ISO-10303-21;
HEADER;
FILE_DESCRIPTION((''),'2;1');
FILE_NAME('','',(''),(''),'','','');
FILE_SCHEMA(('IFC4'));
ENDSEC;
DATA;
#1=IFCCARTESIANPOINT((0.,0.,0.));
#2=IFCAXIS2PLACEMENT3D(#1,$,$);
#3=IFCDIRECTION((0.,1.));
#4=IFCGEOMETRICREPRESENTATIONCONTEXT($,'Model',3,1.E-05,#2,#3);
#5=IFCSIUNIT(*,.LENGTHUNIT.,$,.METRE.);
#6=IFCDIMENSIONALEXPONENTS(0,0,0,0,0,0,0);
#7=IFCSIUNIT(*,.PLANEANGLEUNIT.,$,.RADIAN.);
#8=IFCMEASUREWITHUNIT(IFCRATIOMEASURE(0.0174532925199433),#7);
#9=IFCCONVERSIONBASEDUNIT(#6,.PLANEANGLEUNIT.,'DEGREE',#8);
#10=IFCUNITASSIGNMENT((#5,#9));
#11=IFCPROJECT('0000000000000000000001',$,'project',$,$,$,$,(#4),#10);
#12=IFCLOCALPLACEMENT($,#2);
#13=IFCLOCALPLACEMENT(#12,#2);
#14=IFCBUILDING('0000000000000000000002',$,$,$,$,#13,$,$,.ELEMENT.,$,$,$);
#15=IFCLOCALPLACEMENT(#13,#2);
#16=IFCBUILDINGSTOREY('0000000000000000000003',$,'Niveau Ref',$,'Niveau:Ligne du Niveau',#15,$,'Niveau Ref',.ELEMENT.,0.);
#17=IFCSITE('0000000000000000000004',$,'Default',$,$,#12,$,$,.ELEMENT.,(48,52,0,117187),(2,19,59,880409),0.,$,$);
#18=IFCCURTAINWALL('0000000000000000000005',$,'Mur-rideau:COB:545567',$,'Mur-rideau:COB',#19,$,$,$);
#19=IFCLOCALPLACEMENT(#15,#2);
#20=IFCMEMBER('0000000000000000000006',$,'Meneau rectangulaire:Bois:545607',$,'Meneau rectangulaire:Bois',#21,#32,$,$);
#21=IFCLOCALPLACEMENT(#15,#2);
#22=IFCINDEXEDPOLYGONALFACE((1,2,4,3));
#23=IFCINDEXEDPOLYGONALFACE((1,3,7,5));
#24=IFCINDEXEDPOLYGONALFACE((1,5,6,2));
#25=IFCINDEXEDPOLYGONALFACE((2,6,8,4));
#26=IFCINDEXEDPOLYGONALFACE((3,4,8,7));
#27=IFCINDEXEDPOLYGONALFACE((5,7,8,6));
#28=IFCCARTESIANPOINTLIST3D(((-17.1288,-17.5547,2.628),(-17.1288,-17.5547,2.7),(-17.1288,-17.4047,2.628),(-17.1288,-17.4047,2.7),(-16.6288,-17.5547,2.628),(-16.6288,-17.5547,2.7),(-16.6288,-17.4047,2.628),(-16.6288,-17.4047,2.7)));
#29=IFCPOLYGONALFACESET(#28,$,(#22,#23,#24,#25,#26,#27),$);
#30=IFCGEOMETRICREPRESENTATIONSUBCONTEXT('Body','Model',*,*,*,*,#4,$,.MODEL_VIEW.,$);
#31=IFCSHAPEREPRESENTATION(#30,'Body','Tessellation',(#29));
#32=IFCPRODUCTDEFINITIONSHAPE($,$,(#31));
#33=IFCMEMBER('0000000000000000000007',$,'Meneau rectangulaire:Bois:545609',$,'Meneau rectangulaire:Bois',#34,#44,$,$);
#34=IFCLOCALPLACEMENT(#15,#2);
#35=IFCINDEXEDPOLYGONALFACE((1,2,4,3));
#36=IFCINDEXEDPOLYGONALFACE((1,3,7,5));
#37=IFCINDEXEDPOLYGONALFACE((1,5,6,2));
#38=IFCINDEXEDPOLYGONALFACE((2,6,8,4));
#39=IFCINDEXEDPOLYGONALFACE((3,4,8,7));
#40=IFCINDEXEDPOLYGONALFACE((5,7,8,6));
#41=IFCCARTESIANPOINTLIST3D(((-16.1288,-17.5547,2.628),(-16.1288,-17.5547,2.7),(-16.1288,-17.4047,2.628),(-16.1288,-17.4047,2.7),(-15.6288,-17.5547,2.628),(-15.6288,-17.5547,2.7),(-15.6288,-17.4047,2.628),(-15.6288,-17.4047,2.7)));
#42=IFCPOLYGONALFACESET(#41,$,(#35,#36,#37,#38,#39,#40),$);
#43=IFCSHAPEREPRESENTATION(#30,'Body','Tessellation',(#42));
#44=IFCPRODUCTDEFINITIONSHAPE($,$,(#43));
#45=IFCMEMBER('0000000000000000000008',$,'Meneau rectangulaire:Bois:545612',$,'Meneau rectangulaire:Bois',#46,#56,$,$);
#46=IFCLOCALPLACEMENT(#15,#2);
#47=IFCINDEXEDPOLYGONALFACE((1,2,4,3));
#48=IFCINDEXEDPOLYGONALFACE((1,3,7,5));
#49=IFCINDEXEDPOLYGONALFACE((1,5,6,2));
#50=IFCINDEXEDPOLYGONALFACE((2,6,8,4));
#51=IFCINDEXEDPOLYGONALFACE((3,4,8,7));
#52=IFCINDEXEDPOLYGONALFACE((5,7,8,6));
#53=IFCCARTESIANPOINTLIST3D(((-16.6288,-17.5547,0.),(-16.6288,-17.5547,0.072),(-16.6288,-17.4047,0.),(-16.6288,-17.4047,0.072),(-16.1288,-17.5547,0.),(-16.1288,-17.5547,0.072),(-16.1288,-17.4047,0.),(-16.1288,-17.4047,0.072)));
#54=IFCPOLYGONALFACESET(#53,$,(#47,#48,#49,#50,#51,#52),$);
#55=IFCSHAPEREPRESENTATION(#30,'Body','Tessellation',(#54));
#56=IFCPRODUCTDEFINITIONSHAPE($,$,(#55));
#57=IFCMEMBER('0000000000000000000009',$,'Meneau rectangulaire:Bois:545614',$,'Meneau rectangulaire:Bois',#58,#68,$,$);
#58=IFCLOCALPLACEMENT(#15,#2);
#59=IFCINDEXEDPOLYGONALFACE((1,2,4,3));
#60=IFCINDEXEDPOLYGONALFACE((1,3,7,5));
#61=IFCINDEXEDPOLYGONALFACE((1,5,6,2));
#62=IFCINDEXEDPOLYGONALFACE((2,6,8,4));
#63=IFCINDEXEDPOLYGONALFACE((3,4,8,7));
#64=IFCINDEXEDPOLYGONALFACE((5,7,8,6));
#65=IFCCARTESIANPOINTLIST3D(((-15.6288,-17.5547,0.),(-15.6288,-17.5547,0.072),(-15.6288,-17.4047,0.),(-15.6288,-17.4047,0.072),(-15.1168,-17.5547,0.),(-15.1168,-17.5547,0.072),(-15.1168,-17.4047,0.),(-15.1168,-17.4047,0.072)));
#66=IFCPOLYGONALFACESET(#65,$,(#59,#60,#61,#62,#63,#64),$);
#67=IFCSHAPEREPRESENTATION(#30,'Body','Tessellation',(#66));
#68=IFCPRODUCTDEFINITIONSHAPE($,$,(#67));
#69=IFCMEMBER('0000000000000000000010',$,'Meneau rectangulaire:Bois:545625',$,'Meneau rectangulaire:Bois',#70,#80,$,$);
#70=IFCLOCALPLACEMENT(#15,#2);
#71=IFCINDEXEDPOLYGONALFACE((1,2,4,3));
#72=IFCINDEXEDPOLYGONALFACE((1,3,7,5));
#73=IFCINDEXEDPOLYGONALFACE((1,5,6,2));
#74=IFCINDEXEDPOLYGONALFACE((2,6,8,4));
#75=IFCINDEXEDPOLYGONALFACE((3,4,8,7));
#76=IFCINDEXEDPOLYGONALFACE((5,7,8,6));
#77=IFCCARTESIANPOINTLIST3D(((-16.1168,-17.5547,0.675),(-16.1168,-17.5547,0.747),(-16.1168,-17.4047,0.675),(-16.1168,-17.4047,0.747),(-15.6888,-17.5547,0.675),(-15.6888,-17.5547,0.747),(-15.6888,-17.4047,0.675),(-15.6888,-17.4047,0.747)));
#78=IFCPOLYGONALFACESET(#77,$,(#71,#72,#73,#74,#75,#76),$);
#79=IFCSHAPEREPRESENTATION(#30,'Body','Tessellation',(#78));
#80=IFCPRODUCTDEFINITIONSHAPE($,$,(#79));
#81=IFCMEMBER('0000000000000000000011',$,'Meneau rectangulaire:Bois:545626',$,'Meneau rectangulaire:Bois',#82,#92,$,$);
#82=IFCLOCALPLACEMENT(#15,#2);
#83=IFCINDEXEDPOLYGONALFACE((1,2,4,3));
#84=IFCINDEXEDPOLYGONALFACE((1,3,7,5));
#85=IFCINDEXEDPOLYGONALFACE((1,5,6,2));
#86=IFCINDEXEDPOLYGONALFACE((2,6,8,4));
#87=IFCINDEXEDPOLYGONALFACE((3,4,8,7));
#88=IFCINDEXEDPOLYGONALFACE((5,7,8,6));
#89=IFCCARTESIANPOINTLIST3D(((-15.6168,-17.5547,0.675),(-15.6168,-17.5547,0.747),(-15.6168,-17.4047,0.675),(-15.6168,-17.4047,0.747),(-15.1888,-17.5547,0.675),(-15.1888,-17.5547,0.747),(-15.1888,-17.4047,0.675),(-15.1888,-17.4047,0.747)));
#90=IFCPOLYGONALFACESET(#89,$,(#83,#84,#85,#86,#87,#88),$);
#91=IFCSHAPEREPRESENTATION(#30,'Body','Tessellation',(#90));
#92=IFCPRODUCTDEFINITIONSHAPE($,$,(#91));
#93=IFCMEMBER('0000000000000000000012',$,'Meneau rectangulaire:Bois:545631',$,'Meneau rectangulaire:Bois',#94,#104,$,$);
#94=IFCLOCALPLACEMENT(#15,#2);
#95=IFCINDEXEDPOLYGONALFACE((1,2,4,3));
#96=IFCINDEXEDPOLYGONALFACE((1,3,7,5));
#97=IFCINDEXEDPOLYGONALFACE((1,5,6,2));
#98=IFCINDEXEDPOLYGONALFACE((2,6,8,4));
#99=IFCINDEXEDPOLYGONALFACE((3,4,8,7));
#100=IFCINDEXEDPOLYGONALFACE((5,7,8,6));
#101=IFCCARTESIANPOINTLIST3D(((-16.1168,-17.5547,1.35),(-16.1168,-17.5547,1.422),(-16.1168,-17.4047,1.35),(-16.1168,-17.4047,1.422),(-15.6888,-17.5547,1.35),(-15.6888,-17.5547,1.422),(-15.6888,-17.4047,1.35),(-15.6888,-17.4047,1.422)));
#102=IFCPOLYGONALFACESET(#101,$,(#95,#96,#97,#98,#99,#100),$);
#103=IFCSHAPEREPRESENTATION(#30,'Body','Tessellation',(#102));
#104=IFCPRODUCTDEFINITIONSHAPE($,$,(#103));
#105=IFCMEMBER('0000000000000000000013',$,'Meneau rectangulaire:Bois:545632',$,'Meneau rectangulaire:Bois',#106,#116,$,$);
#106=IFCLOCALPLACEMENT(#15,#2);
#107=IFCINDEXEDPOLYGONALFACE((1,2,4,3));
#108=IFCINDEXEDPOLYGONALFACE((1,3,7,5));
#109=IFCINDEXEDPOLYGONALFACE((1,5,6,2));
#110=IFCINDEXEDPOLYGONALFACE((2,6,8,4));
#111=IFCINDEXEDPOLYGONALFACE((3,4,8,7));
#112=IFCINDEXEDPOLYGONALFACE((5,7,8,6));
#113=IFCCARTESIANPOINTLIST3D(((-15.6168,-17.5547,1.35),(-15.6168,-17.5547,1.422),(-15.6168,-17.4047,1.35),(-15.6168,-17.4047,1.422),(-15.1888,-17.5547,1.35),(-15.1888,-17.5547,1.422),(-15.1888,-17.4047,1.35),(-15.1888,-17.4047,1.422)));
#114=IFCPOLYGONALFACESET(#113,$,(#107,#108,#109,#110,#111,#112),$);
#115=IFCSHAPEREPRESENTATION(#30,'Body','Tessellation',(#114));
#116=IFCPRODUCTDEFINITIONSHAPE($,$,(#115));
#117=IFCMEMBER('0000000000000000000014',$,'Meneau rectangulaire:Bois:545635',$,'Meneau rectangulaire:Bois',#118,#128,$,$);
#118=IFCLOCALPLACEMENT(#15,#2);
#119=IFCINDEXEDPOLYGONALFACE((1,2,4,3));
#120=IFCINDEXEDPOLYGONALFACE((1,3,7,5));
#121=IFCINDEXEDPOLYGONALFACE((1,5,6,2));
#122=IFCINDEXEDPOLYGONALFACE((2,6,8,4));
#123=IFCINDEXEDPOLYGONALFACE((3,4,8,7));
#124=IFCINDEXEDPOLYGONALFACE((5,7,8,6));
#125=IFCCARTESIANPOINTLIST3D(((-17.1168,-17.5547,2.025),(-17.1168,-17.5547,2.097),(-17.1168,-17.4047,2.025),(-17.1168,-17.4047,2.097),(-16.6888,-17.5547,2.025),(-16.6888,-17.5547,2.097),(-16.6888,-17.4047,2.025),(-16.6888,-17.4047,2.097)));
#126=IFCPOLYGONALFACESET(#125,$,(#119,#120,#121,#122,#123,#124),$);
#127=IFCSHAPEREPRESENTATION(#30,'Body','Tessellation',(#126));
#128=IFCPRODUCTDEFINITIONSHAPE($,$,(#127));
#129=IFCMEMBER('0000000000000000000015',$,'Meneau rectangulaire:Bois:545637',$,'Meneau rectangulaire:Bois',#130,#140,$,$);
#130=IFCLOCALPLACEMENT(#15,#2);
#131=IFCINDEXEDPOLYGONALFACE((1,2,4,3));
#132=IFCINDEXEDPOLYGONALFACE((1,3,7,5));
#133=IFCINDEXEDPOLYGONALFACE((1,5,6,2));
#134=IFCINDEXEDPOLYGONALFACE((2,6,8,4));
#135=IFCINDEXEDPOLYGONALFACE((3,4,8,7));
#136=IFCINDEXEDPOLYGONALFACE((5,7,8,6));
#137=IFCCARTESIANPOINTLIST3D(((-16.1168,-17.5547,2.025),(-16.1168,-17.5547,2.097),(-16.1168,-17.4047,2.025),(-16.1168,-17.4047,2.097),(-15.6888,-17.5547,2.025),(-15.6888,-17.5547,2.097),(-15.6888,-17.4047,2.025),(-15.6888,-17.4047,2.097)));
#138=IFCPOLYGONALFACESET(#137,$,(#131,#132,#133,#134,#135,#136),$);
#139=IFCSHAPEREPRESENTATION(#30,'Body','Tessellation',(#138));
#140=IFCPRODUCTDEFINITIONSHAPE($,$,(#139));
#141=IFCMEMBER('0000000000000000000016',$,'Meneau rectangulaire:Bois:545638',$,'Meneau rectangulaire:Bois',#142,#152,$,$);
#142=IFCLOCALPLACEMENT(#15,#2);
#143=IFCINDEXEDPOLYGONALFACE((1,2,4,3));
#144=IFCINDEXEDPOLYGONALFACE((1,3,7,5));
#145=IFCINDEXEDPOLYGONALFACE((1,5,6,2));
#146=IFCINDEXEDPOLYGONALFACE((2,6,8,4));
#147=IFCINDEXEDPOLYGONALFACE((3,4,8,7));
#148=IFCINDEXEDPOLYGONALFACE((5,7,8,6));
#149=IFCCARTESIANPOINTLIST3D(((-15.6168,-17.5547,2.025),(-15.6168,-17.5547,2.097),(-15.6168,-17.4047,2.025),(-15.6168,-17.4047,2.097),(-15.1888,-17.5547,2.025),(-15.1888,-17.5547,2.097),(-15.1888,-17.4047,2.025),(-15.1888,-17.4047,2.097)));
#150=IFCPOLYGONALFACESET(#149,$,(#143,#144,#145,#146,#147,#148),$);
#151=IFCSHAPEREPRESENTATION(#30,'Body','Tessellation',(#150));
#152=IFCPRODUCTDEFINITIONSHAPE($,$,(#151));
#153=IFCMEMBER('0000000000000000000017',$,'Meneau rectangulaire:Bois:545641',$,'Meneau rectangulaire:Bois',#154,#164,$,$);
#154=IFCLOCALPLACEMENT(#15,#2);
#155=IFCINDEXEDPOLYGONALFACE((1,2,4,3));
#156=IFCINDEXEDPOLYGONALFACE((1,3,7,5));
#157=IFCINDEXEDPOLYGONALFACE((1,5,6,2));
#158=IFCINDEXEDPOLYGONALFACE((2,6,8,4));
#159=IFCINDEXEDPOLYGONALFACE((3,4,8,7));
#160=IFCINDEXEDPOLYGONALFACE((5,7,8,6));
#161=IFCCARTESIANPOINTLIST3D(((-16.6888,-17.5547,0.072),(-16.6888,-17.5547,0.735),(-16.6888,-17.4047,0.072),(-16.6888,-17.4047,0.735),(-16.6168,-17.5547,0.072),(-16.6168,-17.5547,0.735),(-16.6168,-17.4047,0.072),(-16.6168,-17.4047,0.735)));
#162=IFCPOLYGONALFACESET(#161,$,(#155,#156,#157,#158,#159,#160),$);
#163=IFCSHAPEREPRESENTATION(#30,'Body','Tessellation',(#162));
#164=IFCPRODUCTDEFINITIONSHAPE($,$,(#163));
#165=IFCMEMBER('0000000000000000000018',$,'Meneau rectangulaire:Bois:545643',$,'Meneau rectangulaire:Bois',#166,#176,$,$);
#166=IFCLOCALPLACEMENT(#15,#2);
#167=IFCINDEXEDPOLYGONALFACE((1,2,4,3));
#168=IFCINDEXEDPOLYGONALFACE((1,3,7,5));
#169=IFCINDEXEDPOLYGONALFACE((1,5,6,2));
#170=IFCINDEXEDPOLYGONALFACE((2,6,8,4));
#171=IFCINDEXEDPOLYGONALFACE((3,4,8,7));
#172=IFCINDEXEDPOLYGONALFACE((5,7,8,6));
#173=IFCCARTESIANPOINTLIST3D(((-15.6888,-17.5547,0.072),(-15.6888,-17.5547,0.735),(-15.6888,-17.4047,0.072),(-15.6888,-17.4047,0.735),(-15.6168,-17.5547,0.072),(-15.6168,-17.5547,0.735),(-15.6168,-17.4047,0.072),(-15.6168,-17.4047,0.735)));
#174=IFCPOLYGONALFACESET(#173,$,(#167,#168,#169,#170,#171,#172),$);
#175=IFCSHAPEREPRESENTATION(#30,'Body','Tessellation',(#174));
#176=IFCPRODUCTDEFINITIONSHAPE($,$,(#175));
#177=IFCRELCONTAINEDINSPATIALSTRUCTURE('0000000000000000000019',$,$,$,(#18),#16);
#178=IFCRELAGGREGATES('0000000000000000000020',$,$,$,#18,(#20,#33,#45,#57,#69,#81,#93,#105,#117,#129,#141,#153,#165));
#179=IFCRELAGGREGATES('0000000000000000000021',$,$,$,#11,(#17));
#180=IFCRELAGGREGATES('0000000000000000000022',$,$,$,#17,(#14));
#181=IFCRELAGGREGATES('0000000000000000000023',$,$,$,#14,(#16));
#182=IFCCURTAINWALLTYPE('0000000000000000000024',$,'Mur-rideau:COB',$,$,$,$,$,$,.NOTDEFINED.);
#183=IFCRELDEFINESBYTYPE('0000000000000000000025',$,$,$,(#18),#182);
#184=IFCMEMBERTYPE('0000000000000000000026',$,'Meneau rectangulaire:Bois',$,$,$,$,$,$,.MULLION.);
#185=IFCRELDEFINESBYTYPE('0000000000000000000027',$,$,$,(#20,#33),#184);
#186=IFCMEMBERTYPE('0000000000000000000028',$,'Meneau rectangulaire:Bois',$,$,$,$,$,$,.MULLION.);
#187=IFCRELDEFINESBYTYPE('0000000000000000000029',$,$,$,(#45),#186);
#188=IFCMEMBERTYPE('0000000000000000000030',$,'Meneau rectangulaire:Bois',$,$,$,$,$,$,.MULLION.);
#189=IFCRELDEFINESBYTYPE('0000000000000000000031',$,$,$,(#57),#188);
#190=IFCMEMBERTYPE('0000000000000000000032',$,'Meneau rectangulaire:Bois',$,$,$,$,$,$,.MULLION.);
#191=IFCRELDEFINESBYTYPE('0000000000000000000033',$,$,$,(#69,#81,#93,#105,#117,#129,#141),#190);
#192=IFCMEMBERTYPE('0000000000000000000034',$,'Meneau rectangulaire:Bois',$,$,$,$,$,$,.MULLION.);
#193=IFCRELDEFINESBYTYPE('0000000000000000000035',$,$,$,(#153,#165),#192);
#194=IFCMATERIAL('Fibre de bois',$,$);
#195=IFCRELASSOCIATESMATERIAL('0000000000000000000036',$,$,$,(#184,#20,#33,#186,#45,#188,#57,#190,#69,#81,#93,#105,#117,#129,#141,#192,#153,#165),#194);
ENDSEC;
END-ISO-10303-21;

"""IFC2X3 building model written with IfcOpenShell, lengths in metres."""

from ifc_helpers import new_model, entity, si_unit, converted_unit, direction, frame, origin, origin_2d_with_axis, place, context, subcontext, project, spatial, rectangle, extrude, source, transform, mapped, material, type_object, type_shapes, element, aggregate, save


model = new_model("IFC2X3")

# Units and contexts
model_context = context("Model", 3, precision=1e-05, world=origin(), true_north=direction((0.0, 1.0)))
body_context = subcontext(model_context, "Body", "Model", "MODEL_VIEW")
ifc_project = project(units=[si_unit("LENGTHUNIT", "METRE"), converted_unit("PLANEANGLEUNIT", "DEGREE", entity("IfcRatioMeasure", 0.0174532925199433), si_unit("PLANEANGLEUNIT", "RADIAN"), dimensions=[0, 0, 0, 0, 0, 0, 0])], contexts=[model_context])

# Site, building, storey
site_placement = place(None, origin())
site = spatial("IfcSite", under=ifc_project, at=site_placement, Name="Default", CompositionType="ELEMENT", RefLatitude=(48, 52, 0, 117187), RefLongitude=(2, 19, 59, 880409), RefElevation=0.0)
building_placement = place(site_placement, origin())
building = spatial("IfcBuilding", under=site, at=building_placement, CompositionType="ELEMENT")
storey_placement = place(building_placement, origin())
storey = spatial("IfcBuildingStorey", under=building, at=storey_placement, Name="Niveau Ref", ObjectType="Niveau:Ligne du Niveau", LongName="Niveau Ref", CompositionType="ELEMENT", Elevation=0.0)

# Curtain wall, members
curtain_wall_type_1 = type_object("IfcCurtainWallType", Name="Mur-rideau:COB", PredefinedType="NOTDEFINED")
curtain_wall_1_placement = place(storey_placement, origin())
curtain_wall_1 = element("IfcCurtainWall", 1, at=curtain_wall_1_placement, inside=storey, type_object=curtain_wall_type_1, Name="Mur-rideau:COB:545567", ObjectType="Mur-rideau:COB")
ifc_material_1 = material(Name="Fibre de bois")
member_type_1 = type_object("IfcMemberType", Name="Meneau rectangulaire:Bois", PredefinedType="MULLION", material=ifc_material_1)
shared_shape_1 = source(origin(), body_context, "Body", "SweptSolid", [
    extrude(rectangle(XDim=0.15, YDim=0.072, at=origin_2d_with_axis()), frame((-0.036, 0.0, -0.5), z_axis=(0.0, 0.0, 1.0), x_axis=(0.0, -1.0, 0.0)), (0.0, 0.0, 1.0), 0.5),
])
type_shapes(member_type_1, [shared_shape_1])
member_1_placement = place(storey_placement, frame((-16.6288, -17.4797, 2.7), z_axis=(1.0, 0.0, 0.0), x_axis=(0.0, 0.0, 1.0)))
member_1 = element("IfcMember", 2, at=member_1_placement, type_object=member_type_1, material=ifc_material_1, Name="Meneau rectangulaire:Bois:545607", ObjectType="Meneau rectangulaire:Bois", context=body_context, shape_type="MappedRepresentation", body=[
    mapped(shared_shape_1, transform((0.0, 0.0, 0.0), scale=1.0)),
])
member_2_placement = place(storey_placement, frame((-15.6288, -17.4797, 2.7), z_axis=(1.0, 0.0, 0.0), x_axis=(0.0, 0.0, 1.0)))
member_2 = element("IfcMember", 3, at=member_2_placement, type_object=member_type_1, material=ifc_material_1, Name="Meneau rectangulaire:Bois:545609", ObjectType="Meneau rectangulaire:Bois", context=body_context, shape_type="MappedRepresentation", body=[
    mapped(shared_shape_1, transform((0.0, 0.0, 0.0), scale=1.0)),
])
member_type_2 = type_object("IfcMemberType", Name="Meneau rectangulaire:Bois", PredefinedType="MULLION", material=ifc_material_1)
shared_shape_2 = source(origin(), body_context, "Body", "SweptSolid", [
    extrude(rectangle(XDim=0.15, YDim=0.072, at=origin_2d_with_axis()), frame((-0.036, 0.0, -0.5), z_axis=(0.0, 0.0, 1.0), x_axis=(0.0, -1.0, 0.0)), (0.0, 0.0, 1.0), 0.5),
])
type_shapes(member_type_2, [shared_shape_2])
member_3_placement = place(storey_placement, frame((-16.6288, -17.4797, 0.0), z_axis=(-1.0, 0.0, 0.0), x_axis=(0.0, 0.0, -1.0)))
member_3 = element("IfcMember", 4, at=member_3_placement, type_object=member_type_2, material=ifc_material_1, Name="Meneau rectangulaire:Bois:545612", ObjectType="Meneau rectangulaire:Bois", context=body_context, shape_type="MappedRepresentation", body=[
    mapped(shared_shape_2, transform((0.0, 0.0, 0.0), scale=1.0)),
])
member_type_3 = type_object("IfcMemberType", Name="Meneau rectangulaire:Bois", PredefinedType="MULLION", material=ifc_material_1)
shared_shape_3 = source(origin(), body_context, "Body", "SweptSolid", [
    extrude(rectangle(XDim=0.15, YDim=0.072, at=origin_2d_with_axis()), frame((-0.036, 0.0, -0.512), z_axis=(0.0, 0.0, 1.0), x_axis=(0.0, -1.0, 0.0)), (0.0, 0.0, 1.0), 0.512),
])
type_shapes(member_type_3, [shared_shape_3])
member_4_placement = place(storey_placement, frame((-15.6288, -17.4797, 0.0), z_axis=(-1.0, 0.0, 0.0), x_axis=(0.0, 0.0, -1.0)))
member_4 = element("IfcMember", 5, at=member_4_placement, type_object=member_type_3, material=ifc_material_1, Name="Meneau rectangulaire:Bois:545614", ObjectType="Meneau rectangulaire:Bois", context=body_context, shape_type="MappedRepresentation", body=[
    mapped(shared_shape_3, transform((0.0, 0.0, 0.0), scale=1.0)),
])
member_type_4 = type_object("IfcMemberType", Name="Meneau rectangulaire:Bois", PredefinedType="MULLION", material=ifc_material_1)
shared_shape_4 = source(origin(), body_context, "Body", "SweptSolid", [
    extrude(rectangle(XDim=0.15, YDim=0.072, at=origin_2d_with_axis()), frame((-0.024, 0.0, -0.428), z_axis=(0.0, 0.0, 1.0), x_axis=(0.0, -1.0, 0.0)), (0.0, 0.0, 1.0), 0.428),
])
type_shapes(member_type_4, [shared_shape_4])
member_5_placement = place(storey_placement, frame((-15.6888, -17.4797, 0.735), z_axis=(1.0, 0.0, 0.0), x_axis=(0.0, 0.0, 1.0)))
member_5 = element("IfcMember", 6, at=member_5_placement, type_object=member_type_4, material=ifc_material_1, Name="Meneau rectangulaire:Bois:545625", ObjectType="Meneau rectangulaire:Bois", context=body_context, shape_type="MappedRepresentation", body=[
    mapped(shared_shape_4, transform((0.0, 0.0, 0.0), scale=1.0)),
])
member_6_placement = place(storey_placement, frame((-15.1888, -17.4797, 0.735), z_axis=(1.0, 0.0, 0.0), x_axis=(0.0, 0.0, 1.0)))
member_6 = element("IfcMember", 7, at=member_6_placement, type_object=member_type_4, material=ifc_material_1, Name="Meneau rectangulaire:Bois:545626", ObjectType="Meneau rectangulaire:Bois", context=body_context, shape_type="MappedRepresentation", body=[
    mapped(shared_shape_4, transform((0.0, 0.0, 0.0), scale=1.0)),
])
member_7_placement = place(storey_placement, frame((-15.6888, -17.4797, 1.41), z_axis=(1.0, 0.0, 0.0), x_axis=(0.0, 0.0, 1.0)))
member_7 = element("IfcMember", 8, at=member_7_placement, type_object=member_type_4, material=ifc_material_1, Name="Meneau rectangulaire:Bois:545631", ObjectType="Meneau rectangulaire:Bois", context=body_context, shape_type="MappedRepresentation", body=[
    mapped(shared_shape_4, transform((0.0, 0.0, 0.0), scale=1.0)),
])
member_8_placement = place(storey_placement, frame((-15.1888, -17.4797, 1.41), z_axis=(1.0, 0.0, 0.0), x_axis=(0.0, 0.0, 1.0)))
member_8 = element("IfcMember", 9, at=member_8_placement, type_object=member_type_4, material=ifc_material_1, Name="Meneau rectangulaire:Bois:545632", ObjectType="Meneau rectangulaire:Bois", context=body_context, shape_type="MappedRepresentation", body=[
    mapped(shared_shape_4, transform((0.0, 0.0, 0.0), scale=1.0)),
])
member_9_placement = place(storey_placement, frame((-16.6888, -17.4797, 2.085), z_axis=(1.0, 0.0, 0.0), x_axis=(0.0, 0.0, 1.0)))
member_9 = element("IfcMember", 10, at=member_9_placement, type_object=member_type_4, material=ifc_material_1, Name="Meneau rectangulaire:Bois:545635", ObjectType="Meneau rectangulaire:Bois", context=body_context, shape_type="MappedRepresentation", body=[
    mapped(shared_shape_4, transform((0.0, 0.0, 0.0), scale=1.0)),
])
member_10_placement = place(storey_placement, frame((-15.6888, -17.4797, 2.085), z_axis=(1.0, 0.0, 0.0), x_axis=(0.0, 0.0, 1.0)))
member_10 = element("IfcMember", 11, at=member_10_placement, type_object=member_type_4, material=ifc_material_1, Name="Meneau rectangulaire:Bois:545637", ObjectType="Meneau rectangulaire:Bois", context=body_context, shape_type="MappedRepresentation", body=[
    mapped(shared_shape_4, transform((0.0, 0.0, 0.0), scale=1.0)),
])
member_11_placement = place(storey_placement, frame((-15.1888, -17.4797, 2.085), z_axis=(1.0, 0.0, 0.0), x_axis=(0.0, 0.0, 1.0)))
member_11 = element("IfcMember", 12, at=member_11_placement, type_object=member_type_4, material=ifc_material_1, Name="Meneau rectangulaire:Bois:545638", ObjectType="Meneau rectangulaire:Bois", context=body_context, shape_type="MappedRepresentation", body=[
    mapped(shared_shape_4, transform((0.0, 0.0, 0.0), scale=1.0)),
])
member_type_5 = type_object("IfcMemberType", Name="Meneau rectangulaire:Bois", PredefinedType="MULLION", material=ifc_material_1)
shared_shape_5 = source(origin(), body_context, "Body", "SweptSolid", [
    extrude(rectangle(XDim=0.15, YDim=0.072, at=origin_2d_with_axis()), frame((-0.024, 0.0, -0.663), z_axis=(0.0, 0.0, 1.0), x_axis=(0.0, -1.0, 0.0)), (0.0, 0.0, 1.0), 0.663),
])
type_shapes(member_type_5, [shared_shape_5])
member_12_placement = place(storey_placement, frame((-16.6288, -17.4797, 0.072), z_axis=(0.0, 0.0, -1.0), x_axis=(1.0, 0.0, 0.0)))
member_12 = element("IfcMember", 13, at=member_12_placement, type_object=member_type_5, material=ifc_material_1, Name="Meneau rectangulaire:Bois:545641", ObjectType="Meneau rectangulaire:Bois", context=body_context, shape_type="MappedRepresentation", body=[
    mapped(shared_shape_5, transform((0.0, 0.0, 0.0), scale=1.0)),
])
member_13_placement = place(storey_placement, frame((-15.6288, -17.4797, 0.072), z_axis=(0.0, 0.0, -1.0), x_axis=(1.0, 0.0, 0.0)))
member_13 = element("IfcMember", 14, at=member_13_placement, type_object=member_type_5, material=ifc_material_1, Name="Meneau rectangulaire:Bois:545643", ObjectType="Meneau rectangulaire:Bois", context=body_context, shape_type="MappedRepresentation", body=[
    mapped(shared_shape_5, transform((0.0, 0.0, 0.0), scale=1.0)),
])
aggregate(curtain_wall_1, [member_1, member_2, member_3, member_4, member_5, member_6, member_7, member_8, member_9, member_10, member_11, member_12, member_13])

save(model, "model.ifc")
